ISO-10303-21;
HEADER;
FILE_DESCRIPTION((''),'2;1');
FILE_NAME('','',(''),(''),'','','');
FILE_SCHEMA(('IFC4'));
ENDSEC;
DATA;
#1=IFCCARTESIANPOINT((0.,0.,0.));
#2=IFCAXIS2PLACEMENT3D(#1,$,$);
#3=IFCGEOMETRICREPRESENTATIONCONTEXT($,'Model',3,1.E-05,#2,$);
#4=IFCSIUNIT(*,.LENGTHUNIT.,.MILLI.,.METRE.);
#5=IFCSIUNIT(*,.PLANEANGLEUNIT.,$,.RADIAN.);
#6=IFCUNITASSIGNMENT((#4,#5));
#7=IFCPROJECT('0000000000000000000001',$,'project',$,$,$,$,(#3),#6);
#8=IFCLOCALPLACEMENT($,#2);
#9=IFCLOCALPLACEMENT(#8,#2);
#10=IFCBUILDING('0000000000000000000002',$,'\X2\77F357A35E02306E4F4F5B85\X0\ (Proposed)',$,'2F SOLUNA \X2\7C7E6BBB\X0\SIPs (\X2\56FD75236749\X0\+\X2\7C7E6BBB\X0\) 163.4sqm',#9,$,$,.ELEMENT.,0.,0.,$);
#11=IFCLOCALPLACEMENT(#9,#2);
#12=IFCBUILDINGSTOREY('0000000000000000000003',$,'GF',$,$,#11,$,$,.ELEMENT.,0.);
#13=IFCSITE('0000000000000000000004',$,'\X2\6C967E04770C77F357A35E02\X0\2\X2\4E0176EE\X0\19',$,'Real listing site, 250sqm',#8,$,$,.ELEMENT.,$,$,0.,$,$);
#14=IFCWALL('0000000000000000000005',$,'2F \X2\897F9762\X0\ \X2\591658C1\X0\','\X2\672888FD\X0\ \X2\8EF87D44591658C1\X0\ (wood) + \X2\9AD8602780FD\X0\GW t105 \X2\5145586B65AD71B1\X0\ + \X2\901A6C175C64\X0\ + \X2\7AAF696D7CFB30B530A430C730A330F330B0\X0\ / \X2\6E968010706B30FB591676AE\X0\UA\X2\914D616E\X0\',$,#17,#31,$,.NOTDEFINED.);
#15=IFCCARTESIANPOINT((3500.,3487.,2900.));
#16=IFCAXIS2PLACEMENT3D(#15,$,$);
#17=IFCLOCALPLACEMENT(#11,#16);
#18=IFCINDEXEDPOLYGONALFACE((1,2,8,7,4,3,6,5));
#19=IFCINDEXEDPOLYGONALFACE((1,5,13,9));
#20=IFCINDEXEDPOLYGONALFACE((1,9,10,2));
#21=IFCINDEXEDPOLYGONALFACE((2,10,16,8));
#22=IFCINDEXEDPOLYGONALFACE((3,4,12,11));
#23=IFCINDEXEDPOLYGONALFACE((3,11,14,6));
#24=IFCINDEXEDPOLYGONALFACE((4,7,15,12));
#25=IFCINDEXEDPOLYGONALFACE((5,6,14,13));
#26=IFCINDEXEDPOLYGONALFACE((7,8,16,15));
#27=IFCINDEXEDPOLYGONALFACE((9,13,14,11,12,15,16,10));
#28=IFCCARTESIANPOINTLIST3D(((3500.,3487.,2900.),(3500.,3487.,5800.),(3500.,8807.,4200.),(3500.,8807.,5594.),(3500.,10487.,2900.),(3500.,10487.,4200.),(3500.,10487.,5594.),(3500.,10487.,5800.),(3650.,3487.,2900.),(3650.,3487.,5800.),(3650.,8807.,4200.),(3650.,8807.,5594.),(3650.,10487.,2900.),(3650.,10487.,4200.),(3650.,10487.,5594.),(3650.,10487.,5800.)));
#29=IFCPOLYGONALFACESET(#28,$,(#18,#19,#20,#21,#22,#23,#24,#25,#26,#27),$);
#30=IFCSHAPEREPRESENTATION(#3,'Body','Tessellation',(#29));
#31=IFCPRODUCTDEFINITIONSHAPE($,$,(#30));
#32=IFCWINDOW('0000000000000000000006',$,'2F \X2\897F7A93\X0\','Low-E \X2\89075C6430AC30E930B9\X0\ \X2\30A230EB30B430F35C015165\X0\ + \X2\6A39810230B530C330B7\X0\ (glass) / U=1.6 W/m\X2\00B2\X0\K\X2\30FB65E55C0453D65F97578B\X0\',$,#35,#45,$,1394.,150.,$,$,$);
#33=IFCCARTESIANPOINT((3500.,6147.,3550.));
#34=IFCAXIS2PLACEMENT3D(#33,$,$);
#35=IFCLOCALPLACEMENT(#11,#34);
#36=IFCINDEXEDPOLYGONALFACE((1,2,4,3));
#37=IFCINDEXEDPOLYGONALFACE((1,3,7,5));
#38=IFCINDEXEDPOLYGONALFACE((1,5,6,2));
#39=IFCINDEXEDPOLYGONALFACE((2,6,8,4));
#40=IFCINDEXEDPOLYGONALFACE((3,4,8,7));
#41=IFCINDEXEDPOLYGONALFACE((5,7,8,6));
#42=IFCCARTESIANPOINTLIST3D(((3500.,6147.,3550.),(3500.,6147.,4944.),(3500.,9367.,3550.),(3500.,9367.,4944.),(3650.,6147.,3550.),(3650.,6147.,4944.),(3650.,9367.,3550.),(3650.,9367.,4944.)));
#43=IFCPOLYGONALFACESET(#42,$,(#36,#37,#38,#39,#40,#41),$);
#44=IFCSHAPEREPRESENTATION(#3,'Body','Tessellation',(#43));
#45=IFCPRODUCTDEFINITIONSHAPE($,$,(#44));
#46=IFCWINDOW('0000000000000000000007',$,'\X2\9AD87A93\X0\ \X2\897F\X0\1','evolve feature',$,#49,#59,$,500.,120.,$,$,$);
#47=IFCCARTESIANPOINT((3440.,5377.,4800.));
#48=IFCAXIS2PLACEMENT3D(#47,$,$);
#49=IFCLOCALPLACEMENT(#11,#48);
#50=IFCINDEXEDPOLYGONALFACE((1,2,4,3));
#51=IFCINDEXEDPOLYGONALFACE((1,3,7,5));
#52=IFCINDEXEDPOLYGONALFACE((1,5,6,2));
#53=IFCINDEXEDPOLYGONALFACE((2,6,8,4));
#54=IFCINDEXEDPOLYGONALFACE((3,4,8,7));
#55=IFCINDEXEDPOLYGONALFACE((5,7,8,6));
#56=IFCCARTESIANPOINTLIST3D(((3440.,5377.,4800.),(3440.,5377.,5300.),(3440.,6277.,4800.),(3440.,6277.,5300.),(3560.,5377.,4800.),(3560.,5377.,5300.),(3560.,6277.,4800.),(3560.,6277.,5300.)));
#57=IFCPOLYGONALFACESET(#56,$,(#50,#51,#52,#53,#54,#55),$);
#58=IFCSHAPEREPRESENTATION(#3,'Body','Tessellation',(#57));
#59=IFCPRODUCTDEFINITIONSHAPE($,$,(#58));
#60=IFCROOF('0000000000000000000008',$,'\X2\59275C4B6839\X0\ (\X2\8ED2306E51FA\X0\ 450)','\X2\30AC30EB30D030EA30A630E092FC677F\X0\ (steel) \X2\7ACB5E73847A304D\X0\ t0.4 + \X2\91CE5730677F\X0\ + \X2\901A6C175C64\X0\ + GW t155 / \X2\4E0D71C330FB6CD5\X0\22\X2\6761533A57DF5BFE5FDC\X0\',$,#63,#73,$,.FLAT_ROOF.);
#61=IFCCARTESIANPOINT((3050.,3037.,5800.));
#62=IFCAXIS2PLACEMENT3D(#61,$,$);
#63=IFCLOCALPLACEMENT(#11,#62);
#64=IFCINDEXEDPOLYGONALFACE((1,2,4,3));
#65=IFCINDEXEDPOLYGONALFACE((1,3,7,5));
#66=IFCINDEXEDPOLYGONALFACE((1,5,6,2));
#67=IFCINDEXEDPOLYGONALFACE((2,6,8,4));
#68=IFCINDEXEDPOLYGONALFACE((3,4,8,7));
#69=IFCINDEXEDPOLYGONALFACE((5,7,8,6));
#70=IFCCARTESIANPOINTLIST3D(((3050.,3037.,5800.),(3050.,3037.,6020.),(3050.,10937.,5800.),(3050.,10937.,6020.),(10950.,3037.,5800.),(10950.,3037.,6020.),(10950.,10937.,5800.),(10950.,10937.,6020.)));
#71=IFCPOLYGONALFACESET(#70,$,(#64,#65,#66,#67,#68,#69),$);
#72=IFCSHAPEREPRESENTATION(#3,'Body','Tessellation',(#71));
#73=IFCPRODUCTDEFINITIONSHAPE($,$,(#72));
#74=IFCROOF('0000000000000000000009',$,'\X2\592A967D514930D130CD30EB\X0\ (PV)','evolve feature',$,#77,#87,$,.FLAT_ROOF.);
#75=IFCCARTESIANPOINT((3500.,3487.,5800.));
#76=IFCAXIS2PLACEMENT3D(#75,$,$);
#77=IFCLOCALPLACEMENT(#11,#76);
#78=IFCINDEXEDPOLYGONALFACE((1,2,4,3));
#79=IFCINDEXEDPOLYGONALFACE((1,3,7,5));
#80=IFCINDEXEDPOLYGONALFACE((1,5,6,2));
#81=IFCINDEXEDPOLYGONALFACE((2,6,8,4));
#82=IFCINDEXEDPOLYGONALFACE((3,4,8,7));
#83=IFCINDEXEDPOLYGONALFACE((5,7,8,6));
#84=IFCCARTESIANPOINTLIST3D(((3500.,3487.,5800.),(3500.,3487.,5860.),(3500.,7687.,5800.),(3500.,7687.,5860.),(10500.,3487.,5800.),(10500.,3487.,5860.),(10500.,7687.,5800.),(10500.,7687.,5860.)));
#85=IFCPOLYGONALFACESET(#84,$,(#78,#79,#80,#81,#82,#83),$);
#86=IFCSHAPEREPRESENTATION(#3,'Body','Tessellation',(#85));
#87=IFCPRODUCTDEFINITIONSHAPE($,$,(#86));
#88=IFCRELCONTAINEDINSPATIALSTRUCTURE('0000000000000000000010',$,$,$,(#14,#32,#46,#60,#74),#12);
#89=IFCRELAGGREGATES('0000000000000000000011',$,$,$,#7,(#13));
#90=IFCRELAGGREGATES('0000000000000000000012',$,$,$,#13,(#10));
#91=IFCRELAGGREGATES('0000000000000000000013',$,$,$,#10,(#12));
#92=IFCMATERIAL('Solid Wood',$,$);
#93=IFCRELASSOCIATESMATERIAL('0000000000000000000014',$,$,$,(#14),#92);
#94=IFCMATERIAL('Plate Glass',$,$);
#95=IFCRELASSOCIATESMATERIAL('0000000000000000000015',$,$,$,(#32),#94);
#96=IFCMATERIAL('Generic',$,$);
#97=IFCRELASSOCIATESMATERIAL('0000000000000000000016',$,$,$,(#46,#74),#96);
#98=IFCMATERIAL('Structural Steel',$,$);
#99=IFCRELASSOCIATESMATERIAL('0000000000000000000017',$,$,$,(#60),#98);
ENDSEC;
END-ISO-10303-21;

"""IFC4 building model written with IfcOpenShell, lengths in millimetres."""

from ifc_helpers import new_model, si_unit, frame, frame_2d, origin, place, context, project, spatial, rectangle, extrude, material, element, fill, save


model = new_model("IFC4")

# Units and contexts
model_context = context("Model", 3, precision=1e-05, world=origin())
ifc_project = project(units=[si_unit("LENGTHUNIT", "METRE", prefix="MILLI"), si_unit("PLANEANGLEUNIT", "RADIAN")], contexts=[model_context])

# Site, building, storey
site_placement = place(None, origin())
site = spatial("IfcSite", under=ifc_project, at=site_placement, Name="沖縄県石垣市2丁目19", ObjectType="Real listing site, 250sqm", CompositionType="ELEMENT", RefElevation=0.0)
building_placement = place(site_placement, origin())
building = spatial("IfcBuilding", under=site, at=building_placement, Name="石垣市の住宅 (Proposed)", ObjectType="2F SOLUNA 籾殻SIPs (国産杉+籾殻) 163.4sqm", CompositionType="ELEMENT", ElevationOfRefHeight=0.0, ElevationOfTerrain=0.0)
storey_placement = place(building_placement, origin())
storey = spatial("IfcBuildingStorey", under=building, at=storey_placement, Name="GF", CompositionType="ELEMENT", Elevation=0.0)

# Shared definitions
ifc_material_1 = material(Name="Solid Wood")
ifc_material_2 = material(Name="Generic")

# Shared definitions
ifc_material_3 = material(Name="Plate Glass")

# Wall, openings, windows
wall_1_placement = place(storey_placement, frame((3500.0, 3487.0, 2900.0)))
wall_1 = element("IfcWall", 1, at=wall_1_placement, inside=storey, material=ifc_material_1, Name="2F 西面 外壁", Description="木製 軸組外壁 (wood) + 高性能GW t105 充填断熱 + 通気層 + 窯業系サイディング / 準耐火・外皮UA配慮", PredefinedType="NOTDEFINED", context=model_context, shape_type="SweptSolid", body=[
    extrude(rectangle(XDim=150.0, YDim=7000.0, at=frame_2d((75.0, 3500.0))), frame((3500.0, 3487.0, 2900.0)), (0.0, 0.0, 1.0), 2900.0),
])
opening_1_placement = place(storey_placement, frame((3500.0, 6147.0, 3550.0)))
opening_1 = element("IfcOpeningElement", 2, at=opening_1_placement, cuts=wall_1, PredefinedType="NOTDEFINED", context=model_context, shape_type="SweptSolid", body=[
    extrude(rectangle(XDim=150.0, YDim=3220.0, at=frame_2d((75.0, 1610.0))), frame((3500.0, 6147.0, 3550.0)), (0.0, 0.0, 1.0), 1394.0),
])
opening_2_placement = place(storey_placement, frame((3440.0, 5377.0, 4800.0)))
opening_2 = element("IfcOpeningElement", 3, at=opening_2_placement, cuts=wall_1, PredefinedType="NOTDEFINED", context=model_context, shape_type="SweptSolid", body=[
    extrude(rectangle(XDim=120.0, YDim=900.0, at=frame_2d((60.0, 450.0))), frame((3440.0, 5377.0, 4800.0)), (0.0, 0.0, 1.0), 500.0),
])
window_1_placement = place(storey_placement, frame((3500.0, 6147.0, 3550.0)))
window_1 = element("IfcWindow", 4, at=window_1_placement, inside=storey, material=ifc_material_3, Name="2F 西窓", Description="Low-E 複層ガラス アルゴン封入 + 樹脂サッシ (glass) / U=1.6 W/m²K・日射取得型", OverallHeight=1394.0, OverallWidth=150.0, context=model_context, shape_type="SweptSolid", body=[
    extrude(rectangle(XDim=150.0, YDim=3220.0, at=frame_2d((75.0, 1610.0))), frame((3500.0, 6147.0, 3550.0)), (0.0, 0.0, 1.0), 1394.0),
])
fill(opening_1, window_1)
window_2_placement = place(storey_placement, frame((3440.0, 5377.0, 4800.0)))
window_2 = element("IfcWindow", 5, at=window_2_placement, inside=storey, material=ifc_material_2, Name="高窓 西1", Description="evolve feature", OverallHeight=500.0, OverallWidth=120.0, context=model_context, shape_type="SweptSolid", body=[
    extrude(rectangle(XDim=120.0, YDim=900.0, at=frame_2d((60.0, 450.0))), frame((3440.0, 5377.0, 4800.0)), (0.0, 0.0, 1.0), 500.0),
])
fill(opening_2, window_2)

# Roofs
ifc_material_4 = material(Name="Structural Steel")
roof_1_placement = place(storey_placement, frame((3050.0, 3037.0, 5800.0)))
element("IfcRoof", 6, at=roof_1_placement, inside=storey, material=ifc_material_4, Name="大屋根 (軒の出 450)", Description="ガルバリウム鋼板 (steel) 立平葺き t0.4 + 野地板 + 通気層 + GW t155 / 不燃・法22条区域対応", PredefinedType="FLAT_ROOF", context=model_context, shape_type="SweptSolid", body=[
    extrude(rectangle(XDim=7900.0, YDim=7900.0, at=frame_2d((3950.0, 3950.0))), frame((3050.0, 3037.0, 5800.0)), (0.0, 0.0, 1.0), 220.0),
])
roof_2_placement = place(storey_placement, frame((3500.0, 3487.0, 5800.0)))
element("IfcRoof", 7, at=roof_2_placement, inside=storey, material=ifc_material_2, Name="太陽光パネル (PV)", Description="evolve feature", PredefinedType="FLAT_ROOF", context=model_context, shape_type="SweptSolid", body=[
    extrude(rectangle(XDim=7000.0, YDim=4200.0, at=frame_2d((3500.0, 2100.0))), frame((3500.0, 3487.0, 5800.0)), (0.0, 0.0, 1.0), 60.0),
])

save(model, "model.ifc")
